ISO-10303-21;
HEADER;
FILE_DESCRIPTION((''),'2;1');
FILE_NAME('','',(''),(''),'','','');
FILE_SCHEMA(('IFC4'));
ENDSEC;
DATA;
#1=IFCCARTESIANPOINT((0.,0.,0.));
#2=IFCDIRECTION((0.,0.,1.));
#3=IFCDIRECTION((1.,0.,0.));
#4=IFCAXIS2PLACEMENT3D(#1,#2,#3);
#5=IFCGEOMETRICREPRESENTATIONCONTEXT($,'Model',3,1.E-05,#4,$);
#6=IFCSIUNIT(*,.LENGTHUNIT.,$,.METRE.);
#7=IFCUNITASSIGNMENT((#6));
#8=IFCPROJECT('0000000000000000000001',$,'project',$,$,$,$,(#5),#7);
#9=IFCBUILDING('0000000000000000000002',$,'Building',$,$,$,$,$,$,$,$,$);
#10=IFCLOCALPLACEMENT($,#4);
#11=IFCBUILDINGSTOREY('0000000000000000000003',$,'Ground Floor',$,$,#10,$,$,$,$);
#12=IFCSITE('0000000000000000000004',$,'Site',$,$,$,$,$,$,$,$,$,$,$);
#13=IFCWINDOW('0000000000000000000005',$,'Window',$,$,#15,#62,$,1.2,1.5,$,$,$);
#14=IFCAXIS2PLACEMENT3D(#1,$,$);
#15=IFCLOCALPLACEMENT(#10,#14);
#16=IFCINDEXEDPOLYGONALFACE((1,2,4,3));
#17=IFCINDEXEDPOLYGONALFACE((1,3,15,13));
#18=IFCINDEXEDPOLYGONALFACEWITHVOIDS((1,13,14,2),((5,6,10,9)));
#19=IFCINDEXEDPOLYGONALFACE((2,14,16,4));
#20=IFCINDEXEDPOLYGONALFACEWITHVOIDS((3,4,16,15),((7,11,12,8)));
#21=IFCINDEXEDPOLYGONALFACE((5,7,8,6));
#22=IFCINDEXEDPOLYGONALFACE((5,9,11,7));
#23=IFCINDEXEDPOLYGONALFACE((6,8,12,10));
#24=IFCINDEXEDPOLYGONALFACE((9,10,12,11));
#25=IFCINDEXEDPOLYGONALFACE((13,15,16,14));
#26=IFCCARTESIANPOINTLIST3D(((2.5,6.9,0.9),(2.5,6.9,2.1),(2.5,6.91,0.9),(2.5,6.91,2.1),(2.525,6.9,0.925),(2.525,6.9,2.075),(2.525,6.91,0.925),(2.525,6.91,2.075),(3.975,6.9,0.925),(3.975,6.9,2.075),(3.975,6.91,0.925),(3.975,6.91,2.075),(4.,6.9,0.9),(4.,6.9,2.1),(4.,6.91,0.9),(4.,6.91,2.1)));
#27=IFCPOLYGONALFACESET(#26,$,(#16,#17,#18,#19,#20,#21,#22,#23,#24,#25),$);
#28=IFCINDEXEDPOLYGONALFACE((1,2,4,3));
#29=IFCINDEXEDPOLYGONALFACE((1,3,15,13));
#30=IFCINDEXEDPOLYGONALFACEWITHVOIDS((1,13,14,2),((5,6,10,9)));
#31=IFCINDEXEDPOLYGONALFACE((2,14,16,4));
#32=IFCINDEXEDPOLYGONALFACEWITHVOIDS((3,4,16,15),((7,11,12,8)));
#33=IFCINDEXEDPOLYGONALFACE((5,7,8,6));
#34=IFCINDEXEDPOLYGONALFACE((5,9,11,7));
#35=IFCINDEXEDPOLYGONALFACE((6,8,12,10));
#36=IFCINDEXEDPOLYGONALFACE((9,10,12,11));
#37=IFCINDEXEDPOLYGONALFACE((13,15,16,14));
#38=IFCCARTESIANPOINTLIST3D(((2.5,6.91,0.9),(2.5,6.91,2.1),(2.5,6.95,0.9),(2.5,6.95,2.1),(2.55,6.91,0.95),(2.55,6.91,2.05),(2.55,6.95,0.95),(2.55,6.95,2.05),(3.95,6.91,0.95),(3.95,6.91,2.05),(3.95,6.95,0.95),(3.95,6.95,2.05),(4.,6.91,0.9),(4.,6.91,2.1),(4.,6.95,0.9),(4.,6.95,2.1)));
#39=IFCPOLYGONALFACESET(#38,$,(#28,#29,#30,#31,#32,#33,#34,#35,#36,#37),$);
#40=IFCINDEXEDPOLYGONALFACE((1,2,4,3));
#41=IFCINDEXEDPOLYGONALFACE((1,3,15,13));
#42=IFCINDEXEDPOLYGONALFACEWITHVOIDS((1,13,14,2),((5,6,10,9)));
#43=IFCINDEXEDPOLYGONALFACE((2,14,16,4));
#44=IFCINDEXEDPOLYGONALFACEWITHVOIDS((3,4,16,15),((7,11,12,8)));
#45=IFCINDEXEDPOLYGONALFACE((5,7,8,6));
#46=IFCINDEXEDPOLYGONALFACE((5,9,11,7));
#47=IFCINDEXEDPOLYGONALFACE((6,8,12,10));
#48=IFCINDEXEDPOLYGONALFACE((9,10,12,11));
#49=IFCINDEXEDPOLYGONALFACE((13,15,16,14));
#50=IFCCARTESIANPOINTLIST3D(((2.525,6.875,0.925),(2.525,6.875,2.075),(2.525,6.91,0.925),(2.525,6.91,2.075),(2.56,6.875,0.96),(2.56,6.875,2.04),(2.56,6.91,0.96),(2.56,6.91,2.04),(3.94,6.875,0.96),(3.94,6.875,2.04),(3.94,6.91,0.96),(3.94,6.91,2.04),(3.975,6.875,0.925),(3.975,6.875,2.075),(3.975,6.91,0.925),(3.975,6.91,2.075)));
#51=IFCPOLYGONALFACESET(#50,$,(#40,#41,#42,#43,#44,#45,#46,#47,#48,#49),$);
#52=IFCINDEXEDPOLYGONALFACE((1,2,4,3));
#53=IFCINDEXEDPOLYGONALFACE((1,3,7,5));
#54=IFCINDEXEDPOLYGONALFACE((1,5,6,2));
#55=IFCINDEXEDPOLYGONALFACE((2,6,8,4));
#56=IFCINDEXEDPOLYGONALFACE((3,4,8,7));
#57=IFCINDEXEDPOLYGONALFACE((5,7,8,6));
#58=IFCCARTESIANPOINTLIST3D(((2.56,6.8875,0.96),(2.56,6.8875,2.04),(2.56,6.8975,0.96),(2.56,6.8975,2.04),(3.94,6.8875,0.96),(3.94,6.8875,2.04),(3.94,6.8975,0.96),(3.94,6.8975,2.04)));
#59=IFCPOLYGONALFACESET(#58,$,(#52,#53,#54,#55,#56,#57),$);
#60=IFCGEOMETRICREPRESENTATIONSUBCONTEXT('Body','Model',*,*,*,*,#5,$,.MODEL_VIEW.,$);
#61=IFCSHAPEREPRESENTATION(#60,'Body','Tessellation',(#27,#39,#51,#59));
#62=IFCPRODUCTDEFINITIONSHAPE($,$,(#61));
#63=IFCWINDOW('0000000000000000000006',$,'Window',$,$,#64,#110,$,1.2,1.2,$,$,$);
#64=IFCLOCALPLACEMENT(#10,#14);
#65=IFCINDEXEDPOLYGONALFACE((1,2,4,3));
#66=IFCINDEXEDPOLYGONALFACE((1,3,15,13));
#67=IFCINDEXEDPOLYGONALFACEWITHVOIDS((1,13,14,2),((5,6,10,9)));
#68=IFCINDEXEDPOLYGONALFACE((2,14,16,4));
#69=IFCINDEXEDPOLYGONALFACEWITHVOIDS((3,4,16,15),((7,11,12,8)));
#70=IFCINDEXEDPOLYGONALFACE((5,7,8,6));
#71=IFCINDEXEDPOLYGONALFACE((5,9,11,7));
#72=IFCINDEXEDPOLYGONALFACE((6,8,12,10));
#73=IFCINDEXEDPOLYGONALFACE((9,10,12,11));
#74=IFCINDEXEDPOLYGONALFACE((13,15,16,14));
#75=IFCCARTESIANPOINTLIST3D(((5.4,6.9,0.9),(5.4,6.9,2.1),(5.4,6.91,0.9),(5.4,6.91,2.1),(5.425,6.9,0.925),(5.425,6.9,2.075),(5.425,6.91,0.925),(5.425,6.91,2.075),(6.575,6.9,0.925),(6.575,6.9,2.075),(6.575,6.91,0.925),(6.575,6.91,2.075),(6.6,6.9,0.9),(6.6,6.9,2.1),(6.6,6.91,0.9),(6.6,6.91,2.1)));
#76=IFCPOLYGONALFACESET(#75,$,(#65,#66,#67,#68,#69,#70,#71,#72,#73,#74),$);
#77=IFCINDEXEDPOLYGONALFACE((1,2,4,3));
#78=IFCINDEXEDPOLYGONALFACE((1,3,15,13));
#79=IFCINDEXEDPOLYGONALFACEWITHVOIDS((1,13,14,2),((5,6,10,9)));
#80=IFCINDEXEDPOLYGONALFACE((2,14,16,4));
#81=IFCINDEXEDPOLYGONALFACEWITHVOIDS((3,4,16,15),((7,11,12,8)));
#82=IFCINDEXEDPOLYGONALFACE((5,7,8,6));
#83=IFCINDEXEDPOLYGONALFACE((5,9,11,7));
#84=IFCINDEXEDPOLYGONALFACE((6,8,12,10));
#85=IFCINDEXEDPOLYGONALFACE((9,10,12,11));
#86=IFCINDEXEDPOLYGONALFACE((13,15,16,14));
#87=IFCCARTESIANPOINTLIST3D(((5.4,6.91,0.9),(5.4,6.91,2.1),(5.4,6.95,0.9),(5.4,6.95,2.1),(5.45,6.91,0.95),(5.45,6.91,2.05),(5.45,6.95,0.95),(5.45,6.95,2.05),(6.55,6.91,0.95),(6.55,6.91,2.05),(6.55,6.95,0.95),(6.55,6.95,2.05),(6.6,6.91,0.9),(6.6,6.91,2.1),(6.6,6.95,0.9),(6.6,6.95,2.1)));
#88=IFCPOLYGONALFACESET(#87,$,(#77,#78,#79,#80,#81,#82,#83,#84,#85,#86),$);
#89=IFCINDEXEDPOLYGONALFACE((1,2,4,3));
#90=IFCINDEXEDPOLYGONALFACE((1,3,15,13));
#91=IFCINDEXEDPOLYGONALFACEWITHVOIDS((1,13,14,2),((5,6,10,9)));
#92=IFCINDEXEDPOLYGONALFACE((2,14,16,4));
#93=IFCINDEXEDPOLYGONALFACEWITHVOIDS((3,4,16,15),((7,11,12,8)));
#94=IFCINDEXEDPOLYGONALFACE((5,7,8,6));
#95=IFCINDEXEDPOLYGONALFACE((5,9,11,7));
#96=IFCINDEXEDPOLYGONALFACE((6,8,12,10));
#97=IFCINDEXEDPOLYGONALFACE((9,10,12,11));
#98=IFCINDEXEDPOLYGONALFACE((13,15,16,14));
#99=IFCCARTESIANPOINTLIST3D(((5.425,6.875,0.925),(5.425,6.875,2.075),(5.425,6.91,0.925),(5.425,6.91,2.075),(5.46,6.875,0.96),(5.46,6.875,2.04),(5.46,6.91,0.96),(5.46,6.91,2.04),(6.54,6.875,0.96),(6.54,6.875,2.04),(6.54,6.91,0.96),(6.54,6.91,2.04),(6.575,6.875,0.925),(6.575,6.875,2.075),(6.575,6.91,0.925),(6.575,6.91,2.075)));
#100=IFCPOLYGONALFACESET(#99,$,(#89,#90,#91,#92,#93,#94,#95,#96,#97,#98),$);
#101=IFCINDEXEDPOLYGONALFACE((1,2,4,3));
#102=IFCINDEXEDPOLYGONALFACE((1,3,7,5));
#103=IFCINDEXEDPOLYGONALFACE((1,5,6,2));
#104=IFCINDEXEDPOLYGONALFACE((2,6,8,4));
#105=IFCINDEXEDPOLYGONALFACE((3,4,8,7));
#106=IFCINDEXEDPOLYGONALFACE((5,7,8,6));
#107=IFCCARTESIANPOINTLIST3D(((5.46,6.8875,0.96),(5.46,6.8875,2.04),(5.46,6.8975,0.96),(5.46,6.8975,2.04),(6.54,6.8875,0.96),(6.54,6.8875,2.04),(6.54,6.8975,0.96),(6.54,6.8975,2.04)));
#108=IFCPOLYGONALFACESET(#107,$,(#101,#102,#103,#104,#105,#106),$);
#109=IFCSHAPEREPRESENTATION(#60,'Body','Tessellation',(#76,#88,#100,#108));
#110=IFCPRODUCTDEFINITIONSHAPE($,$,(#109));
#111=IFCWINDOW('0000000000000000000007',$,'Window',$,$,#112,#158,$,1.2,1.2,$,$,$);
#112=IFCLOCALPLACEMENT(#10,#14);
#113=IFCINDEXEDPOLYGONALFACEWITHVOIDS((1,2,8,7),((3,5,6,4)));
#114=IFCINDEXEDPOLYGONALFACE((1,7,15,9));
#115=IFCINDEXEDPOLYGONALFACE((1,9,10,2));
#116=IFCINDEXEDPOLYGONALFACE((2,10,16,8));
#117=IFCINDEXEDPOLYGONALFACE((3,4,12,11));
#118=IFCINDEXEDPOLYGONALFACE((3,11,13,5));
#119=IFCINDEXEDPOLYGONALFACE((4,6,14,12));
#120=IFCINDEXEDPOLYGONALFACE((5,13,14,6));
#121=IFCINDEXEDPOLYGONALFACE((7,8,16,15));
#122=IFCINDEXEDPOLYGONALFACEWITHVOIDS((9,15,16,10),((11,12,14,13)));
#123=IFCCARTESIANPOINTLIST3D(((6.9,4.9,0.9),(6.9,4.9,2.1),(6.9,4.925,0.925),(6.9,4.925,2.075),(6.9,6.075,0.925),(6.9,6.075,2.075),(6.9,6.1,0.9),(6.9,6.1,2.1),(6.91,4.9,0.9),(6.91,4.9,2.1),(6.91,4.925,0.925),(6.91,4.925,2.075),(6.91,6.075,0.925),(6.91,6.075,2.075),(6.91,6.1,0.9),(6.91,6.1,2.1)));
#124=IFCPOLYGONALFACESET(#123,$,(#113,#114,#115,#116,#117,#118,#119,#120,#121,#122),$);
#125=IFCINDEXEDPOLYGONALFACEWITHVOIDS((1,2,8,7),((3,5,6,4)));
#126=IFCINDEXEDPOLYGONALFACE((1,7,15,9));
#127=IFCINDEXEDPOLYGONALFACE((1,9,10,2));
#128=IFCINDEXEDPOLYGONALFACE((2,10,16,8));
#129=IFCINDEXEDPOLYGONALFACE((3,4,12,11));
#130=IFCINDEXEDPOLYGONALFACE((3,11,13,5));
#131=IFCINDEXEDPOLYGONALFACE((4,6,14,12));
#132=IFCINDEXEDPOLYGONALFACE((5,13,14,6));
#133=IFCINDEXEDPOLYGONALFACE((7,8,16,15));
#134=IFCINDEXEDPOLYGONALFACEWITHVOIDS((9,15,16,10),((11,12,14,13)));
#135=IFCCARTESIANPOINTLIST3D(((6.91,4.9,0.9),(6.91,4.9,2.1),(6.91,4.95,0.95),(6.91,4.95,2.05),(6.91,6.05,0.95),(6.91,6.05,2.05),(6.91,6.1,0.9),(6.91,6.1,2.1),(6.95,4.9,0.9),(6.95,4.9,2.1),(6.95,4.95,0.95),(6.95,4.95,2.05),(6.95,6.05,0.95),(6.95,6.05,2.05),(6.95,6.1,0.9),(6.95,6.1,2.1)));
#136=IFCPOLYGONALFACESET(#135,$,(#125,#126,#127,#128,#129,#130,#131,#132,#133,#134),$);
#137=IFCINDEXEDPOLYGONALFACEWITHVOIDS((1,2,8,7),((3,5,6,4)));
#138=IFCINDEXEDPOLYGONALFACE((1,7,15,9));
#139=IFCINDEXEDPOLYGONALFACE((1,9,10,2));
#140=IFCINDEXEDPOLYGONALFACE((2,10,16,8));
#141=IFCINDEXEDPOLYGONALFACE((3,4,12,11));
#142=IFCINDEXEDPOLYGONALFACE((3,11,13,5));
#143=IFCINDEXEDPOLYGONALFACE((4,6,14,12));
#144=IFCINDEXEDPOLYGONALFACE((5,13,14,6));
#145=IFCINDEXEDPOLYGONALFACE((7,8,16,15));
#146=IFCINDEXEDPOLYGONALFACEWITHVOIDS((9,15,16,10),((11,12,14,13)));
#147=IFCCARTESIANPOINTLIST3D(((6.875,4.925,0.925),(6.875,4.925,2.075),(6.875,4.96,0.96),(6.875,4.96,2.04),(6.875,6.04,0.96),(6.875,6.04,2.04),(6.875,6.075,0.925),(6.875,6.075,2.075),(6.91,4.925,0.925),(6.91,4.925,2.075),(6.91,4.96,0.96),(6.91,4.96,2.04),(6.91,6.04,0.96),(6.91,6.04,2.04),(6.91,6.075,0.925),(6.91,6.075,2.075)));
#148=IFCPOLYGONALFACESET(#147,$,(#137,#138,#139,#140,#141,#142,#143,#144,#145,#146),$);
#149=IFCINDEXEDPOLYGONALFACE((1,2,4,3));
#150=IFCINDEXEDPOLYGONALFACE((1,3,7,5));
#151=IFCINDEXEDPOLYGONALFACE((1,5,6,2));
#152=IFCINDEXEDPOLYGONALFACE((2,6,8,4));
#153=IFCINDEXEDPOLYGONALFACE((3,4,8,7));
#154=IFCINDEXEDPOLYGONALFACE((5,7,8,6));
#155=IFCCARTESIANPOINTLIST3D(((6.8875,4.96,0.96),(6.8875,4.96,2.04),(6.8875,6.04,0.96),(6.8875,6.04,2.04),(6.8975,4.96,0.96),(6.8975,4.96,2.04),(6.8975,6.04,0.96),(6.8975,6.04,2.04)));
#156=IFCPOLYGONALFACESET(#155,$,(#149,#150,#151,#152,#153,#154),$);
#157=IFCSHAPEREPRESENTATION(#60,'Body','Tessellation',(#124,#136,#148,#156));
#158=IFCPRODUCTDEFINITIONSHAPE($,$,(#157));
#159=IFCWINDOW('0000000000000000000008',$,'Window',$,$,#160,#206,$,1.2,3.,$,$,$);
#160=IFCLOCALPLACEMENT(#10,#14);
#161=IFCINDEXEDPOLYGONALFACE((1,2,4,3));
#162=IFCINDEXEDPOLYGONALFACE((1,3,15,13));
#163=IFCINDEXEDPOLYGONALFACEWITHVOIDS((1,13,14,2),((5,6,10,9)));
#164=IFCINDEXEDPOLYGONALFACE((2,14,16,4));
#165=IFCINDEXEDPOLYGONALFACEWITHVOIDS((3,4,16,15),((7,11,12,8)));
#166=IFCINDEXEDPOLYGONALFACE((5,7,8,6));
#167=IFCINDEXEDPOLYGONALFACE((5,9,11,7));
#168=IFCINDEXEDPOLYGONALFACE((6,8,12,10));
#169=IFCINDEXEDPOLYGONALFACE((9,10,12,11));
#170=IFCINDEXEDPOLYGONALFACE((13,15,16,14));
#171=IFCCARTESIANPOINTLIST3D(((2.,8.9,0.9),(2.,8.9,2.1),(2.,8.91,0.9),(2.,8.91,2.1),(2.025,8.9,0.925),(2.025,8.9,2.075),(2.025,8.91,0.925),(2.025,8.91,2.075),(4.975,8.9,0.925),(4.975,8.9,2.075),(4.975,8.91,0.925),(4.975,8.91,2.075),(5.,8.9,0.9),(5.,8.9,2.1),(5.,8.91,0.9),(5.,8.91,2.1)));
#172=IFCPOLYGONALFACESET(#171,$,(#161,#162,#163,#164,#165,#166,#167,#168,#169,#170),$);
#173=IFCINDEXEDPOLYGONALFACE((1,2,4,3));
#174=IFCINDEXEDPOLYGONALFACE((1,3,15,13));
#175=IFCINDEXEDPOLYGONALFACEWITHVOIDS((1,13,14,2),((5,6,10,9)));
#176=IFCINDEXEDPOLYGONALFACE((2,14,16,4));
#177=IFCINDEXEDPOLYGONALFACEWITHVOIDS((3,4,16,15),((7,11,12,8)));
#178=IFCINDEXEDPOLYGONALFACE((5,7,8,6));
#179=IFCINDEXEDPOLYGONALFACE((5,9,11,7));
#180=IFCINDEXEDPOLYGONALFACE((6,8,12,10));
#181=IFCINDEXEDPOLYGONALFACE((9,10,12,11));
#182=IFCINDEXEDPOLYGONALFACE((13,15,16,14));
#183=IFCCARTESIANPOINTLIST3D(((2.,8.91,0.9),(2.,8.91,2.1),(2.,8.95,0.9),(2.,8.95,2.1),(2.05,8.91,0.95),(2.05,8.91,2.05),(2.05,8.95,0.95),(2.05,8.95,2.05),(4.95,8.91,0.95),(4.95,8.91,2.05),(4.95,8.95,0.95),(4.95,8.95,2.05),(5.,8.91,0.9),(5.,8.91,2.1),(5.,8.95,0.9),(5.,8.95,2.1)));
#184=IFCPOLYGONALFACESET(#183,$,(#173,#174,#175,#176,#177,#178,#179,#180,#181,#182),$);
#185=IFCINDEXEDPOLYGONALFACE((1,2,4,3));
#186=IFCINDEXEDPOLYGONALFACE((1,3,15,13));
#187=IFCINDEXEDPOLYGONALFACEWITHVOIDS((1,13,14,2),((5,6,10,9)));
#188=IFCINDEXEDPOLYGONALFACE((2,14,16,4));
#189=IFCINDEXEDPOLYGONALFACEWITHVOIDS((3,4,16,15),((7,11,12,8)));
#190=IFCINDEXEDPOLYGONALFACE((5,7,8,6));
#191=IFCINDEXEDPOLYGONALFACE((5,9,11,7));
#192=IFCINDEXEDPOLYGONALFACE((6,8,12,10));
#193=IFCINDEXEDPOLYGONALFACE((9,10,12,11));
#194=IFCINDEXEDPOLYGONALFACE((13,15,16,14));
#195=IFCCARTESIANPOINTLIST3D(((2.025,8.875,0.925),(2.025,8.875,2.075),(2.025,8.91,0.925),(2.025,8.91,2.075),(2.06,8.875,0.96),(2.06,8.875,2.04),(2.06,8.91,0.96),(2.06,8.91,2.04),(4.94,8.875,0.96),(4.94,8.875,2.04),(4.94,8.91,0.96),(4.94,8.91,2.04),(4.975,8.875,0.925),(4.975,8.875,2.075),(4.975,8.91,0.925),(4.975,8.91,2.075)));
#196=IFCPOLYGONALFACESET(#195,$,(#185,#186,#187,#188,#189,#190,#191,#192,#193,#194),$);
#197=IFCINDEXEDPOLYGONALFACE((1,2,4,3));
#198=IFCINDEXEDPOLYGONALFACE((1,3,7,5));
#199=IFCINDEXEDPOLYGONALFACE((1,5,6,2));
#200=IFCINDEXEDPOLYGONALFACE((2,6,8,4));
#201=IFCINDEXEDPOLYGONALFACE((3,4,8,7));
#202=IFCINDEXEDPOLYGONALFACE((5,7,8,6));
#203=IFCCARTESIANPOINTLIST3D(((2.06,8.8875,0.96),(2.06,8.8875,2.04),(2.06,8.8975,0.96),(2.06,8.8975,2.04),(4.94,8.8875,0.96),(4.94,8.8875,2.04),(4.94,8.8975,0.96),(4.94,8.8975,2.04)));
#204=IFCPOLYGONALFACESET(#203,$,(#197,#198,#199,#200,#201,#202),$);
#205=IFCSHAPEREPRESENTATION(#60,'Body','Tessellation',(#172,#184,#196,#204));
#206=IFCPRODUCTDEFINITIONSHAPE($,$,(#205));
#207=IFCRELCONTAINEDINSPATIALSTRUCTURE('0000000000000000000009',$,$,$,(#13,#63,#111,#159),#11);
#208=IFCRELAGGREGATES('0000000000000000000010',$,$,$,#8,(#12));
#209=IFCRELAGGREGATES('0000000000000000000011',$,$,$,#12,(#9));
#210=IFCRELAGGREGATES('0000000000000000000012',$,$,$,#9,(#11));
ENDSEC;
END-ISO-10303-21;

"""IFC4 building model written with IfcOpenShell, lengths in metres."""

from ifc_helpers import new_model, si_unit, frame, origin_with_axes, place, context, subcontext, project, spatial, line, indexed_curve, outline, extrude, element, save


model = new_model("IFC4")

# Units and contexts
model_context = context("Model", 3, precision=1e-05, world=origin_with_axes())
body_context = subcontext(model_context, "Body", "Model", "MODEL_VIEW")
ifc_project = project(units=[si_unit("LENGTHUNIT", "METRE")], contexts=[model_context])

# Site, building, storey
site = spatial("IfcSite", under=ifc_project, Name="Site")
building = spatial("IfcBuilding", under=site, Name="Building")
storey_placement = place(None, origin_with_axes())
storey = spatial("IfcBuildingStorey", under=building, at=storey_placement, Name="Ground Floor")

# Windows
window_1_placement = place(storey_placement, frame((4.0, 7.0, 0.9), z_axis=(0.0, 0.0, 1.0), x_axis=(-1.0, 0.0, 0.0)))
element("IfcWindow", 1, at=window_1_placement, inside=storey, Name="Window", OverallHeight=1.2, OverallWidth=1.5, context=body_context, shape_type="SweptSolid", body=[
    extrude(outline(indexed_curve([(0.0, 0.0), (1.5, 0.0), (1.5, 1.2), (0.0, 1.2)], segments=[line(1, 2, 3, 4, 1)]), holes=[indexed_curve([(0.025, 0.025), (1.475, 0.025), (1.475, 1.175), (0.025, 1.175)], segments=[line(1, 2, 3, 4, 1)])]), frame((0.0, 0.09, 0.0), z_axis=(0.0, -1.0, 0.0), x_axis=(1.0, 0.0, 0.0)), (0.0, 0.0, -1.0), 0.01),
    extrude(outline(indexed_curve([(0.0, 0.0), (1.5, 0.0), (1.5, 1.2), (0.0, 1.2)], segments=[line(1, 2, 3, 4, 1)]), holes=[indexed_curve([(0.05, 0.05), (1.45, 0.05), (1.45, 1.15), (0.05, 1.15)], segments=[line(1, 2, 3, 4, 1)])]), frame((0.0, 0.05, 0.0), z_axis=(0.0, -1.0, 0.0), x_axis=(1.0, 0.0, 0.0)), (0.0, 0.0, -1.0), 0.04),
    extrude(outline(indexed_curve([(0.0, 0.0), (1.45, 0.0), (1.45, 1.15), (0.0, 1.15)], segments=[line(1, 2, 3, 4, 1)]), holes=[indexed_curve([(0.035, 0.035), (1.415, 0.035), (1.415, 1.115), (0.035, 1.115)], segments=[line(1, 2, 3, 4, 1)])]), frame((0.025, 0.09, 0.025), z_axis=(0.0, -1.0, 0.0), x_axis=(1.0, 0.0, 0.0)), (0.0, 0.0, -1.0), 0.035),
    extrude(outline(indexed_curve([(0.035, 0.035), (1.415, 0.035), (1.415, 1.115), (0.035, 1.115)], segments=[line(1, 2, 3, 4, 1)])), frame((0.025, 0.1025, 0.025), z_axis=(0.0, -1.0, 0.0), x_axis=(1.0, 0.0, 0.0)), (0.0, 0.0, -1.0), 0.01),
])
for number, where, z_axis, x_axis, name in (
    (2, (6.6, 7.0, 0.9), (0.0, 0.0, 1.0), (-1.0, 0.0, 0.0), "Window"),
    (3, (7.0, 4.9, 0.9), (0.0, 0.0, 1.0), (0.0, 1.0, 0.0), "Window"),
):
    element("IfcWindow", number, at=place(storey_placement, frame(where, z_axis=z_axis, x_axis=x_axis)), inside=storey, Name=name, OverallHeight=1.2, OverallWidth=1.2, context=body_context, shape_type="SweptSolid", body=[
        extrude(outline(indexed_curve([(0.0, 0.0), (1.2, 0.0), (1.2, 1.2), (0.0, 1.2)], segments=[line(1, 2, 3, 4, 1)]), holes=[indexed_curve([(0.025, 0.025), (1.175, 0.025), (1.175, 1.175), (0.025, 1.175)], segments=[line(1, 2, 3, 4, 1)])]), frame((0.0, 0.09, 0.0), z_axis=(0.0, -1.0, 0.0), x_axis=(1.0, 0.0, 0.0)), (0.0, 0.0, -1.0), 0.01),
        extrude(outline(indexed_curve([(0.0, 0.0), (1.2, 0.0), (1.2, 1.2), (0.0, 1.2)], segments=[line(1, 2, 3, 4, 1)]), holes=[indexed_curve([(0.05, 0.05), (1.15, 0.05), (1.15, 1.15), (0.05, 1.15)], segments=[line(1, 2, 3, 4, 1)])]), frame((0.0, 0.05, 0.0), z_axis=(0.0, -1.0, 0.0), x_axis=(1.0, 0.0, 0.0)), (0.0, 0.0, -1.0), 0.04),
        extrude(outline(indexed_curve([(0.0, 0.0), (1.15, 0.0), (1.15, 1.15), (0.0, 1.15)], segments=[line(1, 2, 3, 4, 1)]), holes=[indexed_curve([(0.035, 0.035), (1.115, 0.035), (1.115, 1.115), (0.035, 1.115)], segments=[line(1, 2, 3, 4, 1)])]), frame((0.025, 0.09, 0.025), z_axis=(0.0, -1.0, 0.0), x_axis=(1.0, 0.0, 0.0)), (0.0, 0.0, -1.0), 0.035),
        extrude(outline(indexed_curve([(0.035, 0.035), (1.115, 0.035), (1.115, 1.115), (0.035, 1.115)], segments=[line(1, 2, 3, 4, 1)])), frame((0.025, 0.1025, 0.025), z_axis=(0.0, -1.0, 0.0), x_axis=(1.0, 0.0, 0.0)), (0.0, 0.0, -1.0), 0.01),
    ])
window_2_placement = place(storey_placement, frame((5.0, 9.0, 0.9), z_axis=(0.0, 0.0, 1.0), x_axis=(-1.0, 0.0, 0.0)))
element("IfcWindow", 4, at=window_2_placement, inside=storey, Name="Window", OverallHeight=1.2, OverallWidth=3.0, context=body_context, shape_type="SweptSolid", body=[
    extrude(outline(indexed_curve([(0.0, 0.0), (3.0, 0.0), (3.0, 1.2), (0.0, 1.2)], segments=[line(1, 2, 3, 4, 1)]), holes=[indexed_curve([(0.025, 0.025), (2.975, 0.025), (2.975, 1.175), (0.025, 1.175)], segments=[line(1, 2, 3, 4, 1)])]), frame((0.0, 0.09, 0.0), z_axis=(0.0, -1.0, 0.0), x_axis=(1.0, 0.0, 0.0)), (0.0, 0.0, -1.0), 0.01),
    extrude(outline(indexed_curve([(0.0, 0.0), (3.0, 0.0), (3.0, 1.2), (0.0, 1.2)], segments=[line(1, 2, 3, 4, 1)]), holes=[indexed_curve([(0.05, 0.05), (2.95, 0.05), (2.95, 1.15), (0.05, 1.15)], segments=[line(1, 2, 3, 4, 1)])]), frame((0.0, 0.05, 0.0), z_axis=(0.0, -1.0, 0.0), x_axis=(1.0, 0.0, 0.0)), (0.0, 0.0, -1.0), 0.04),
    extrude(outline(indexed_curve([(0.0, 0.0), (2.95, 0.0), (2.95, 1.15), (0.0, 1.15)], segments=[line(1, 2, 3, 4, 1)]), holes=[indexed_curve([(0.035, 0.035), (2.915, 0.035), (2.915, 1.115), (0.035, 1.115)], segments=[line(1, 2, 3, 4, 1)])]), frame((0.025, 0.09, 0.025), z_axis=(0.0, -1.0, 0.0), x_axis=(1.0, 0.0, 0.0)), (0.0, 0.0, -1.0), 0.035),
    extrude(outline(indexed_curve([(0.035, 0.035), (2.915, 0.035), (2.915, 1.115), (0.035, 1.115)], segments=[line(1, 2, 3, 4, 1)])), frame((0.025, 0.1025, 0.025), z_axis=(0.0, -1.0, 0.0), x_axis=(1.0, 0.0, 0.0)), (0.0, 0.0, -1.0), 0.01),
])

save(model, "model.ifc")
